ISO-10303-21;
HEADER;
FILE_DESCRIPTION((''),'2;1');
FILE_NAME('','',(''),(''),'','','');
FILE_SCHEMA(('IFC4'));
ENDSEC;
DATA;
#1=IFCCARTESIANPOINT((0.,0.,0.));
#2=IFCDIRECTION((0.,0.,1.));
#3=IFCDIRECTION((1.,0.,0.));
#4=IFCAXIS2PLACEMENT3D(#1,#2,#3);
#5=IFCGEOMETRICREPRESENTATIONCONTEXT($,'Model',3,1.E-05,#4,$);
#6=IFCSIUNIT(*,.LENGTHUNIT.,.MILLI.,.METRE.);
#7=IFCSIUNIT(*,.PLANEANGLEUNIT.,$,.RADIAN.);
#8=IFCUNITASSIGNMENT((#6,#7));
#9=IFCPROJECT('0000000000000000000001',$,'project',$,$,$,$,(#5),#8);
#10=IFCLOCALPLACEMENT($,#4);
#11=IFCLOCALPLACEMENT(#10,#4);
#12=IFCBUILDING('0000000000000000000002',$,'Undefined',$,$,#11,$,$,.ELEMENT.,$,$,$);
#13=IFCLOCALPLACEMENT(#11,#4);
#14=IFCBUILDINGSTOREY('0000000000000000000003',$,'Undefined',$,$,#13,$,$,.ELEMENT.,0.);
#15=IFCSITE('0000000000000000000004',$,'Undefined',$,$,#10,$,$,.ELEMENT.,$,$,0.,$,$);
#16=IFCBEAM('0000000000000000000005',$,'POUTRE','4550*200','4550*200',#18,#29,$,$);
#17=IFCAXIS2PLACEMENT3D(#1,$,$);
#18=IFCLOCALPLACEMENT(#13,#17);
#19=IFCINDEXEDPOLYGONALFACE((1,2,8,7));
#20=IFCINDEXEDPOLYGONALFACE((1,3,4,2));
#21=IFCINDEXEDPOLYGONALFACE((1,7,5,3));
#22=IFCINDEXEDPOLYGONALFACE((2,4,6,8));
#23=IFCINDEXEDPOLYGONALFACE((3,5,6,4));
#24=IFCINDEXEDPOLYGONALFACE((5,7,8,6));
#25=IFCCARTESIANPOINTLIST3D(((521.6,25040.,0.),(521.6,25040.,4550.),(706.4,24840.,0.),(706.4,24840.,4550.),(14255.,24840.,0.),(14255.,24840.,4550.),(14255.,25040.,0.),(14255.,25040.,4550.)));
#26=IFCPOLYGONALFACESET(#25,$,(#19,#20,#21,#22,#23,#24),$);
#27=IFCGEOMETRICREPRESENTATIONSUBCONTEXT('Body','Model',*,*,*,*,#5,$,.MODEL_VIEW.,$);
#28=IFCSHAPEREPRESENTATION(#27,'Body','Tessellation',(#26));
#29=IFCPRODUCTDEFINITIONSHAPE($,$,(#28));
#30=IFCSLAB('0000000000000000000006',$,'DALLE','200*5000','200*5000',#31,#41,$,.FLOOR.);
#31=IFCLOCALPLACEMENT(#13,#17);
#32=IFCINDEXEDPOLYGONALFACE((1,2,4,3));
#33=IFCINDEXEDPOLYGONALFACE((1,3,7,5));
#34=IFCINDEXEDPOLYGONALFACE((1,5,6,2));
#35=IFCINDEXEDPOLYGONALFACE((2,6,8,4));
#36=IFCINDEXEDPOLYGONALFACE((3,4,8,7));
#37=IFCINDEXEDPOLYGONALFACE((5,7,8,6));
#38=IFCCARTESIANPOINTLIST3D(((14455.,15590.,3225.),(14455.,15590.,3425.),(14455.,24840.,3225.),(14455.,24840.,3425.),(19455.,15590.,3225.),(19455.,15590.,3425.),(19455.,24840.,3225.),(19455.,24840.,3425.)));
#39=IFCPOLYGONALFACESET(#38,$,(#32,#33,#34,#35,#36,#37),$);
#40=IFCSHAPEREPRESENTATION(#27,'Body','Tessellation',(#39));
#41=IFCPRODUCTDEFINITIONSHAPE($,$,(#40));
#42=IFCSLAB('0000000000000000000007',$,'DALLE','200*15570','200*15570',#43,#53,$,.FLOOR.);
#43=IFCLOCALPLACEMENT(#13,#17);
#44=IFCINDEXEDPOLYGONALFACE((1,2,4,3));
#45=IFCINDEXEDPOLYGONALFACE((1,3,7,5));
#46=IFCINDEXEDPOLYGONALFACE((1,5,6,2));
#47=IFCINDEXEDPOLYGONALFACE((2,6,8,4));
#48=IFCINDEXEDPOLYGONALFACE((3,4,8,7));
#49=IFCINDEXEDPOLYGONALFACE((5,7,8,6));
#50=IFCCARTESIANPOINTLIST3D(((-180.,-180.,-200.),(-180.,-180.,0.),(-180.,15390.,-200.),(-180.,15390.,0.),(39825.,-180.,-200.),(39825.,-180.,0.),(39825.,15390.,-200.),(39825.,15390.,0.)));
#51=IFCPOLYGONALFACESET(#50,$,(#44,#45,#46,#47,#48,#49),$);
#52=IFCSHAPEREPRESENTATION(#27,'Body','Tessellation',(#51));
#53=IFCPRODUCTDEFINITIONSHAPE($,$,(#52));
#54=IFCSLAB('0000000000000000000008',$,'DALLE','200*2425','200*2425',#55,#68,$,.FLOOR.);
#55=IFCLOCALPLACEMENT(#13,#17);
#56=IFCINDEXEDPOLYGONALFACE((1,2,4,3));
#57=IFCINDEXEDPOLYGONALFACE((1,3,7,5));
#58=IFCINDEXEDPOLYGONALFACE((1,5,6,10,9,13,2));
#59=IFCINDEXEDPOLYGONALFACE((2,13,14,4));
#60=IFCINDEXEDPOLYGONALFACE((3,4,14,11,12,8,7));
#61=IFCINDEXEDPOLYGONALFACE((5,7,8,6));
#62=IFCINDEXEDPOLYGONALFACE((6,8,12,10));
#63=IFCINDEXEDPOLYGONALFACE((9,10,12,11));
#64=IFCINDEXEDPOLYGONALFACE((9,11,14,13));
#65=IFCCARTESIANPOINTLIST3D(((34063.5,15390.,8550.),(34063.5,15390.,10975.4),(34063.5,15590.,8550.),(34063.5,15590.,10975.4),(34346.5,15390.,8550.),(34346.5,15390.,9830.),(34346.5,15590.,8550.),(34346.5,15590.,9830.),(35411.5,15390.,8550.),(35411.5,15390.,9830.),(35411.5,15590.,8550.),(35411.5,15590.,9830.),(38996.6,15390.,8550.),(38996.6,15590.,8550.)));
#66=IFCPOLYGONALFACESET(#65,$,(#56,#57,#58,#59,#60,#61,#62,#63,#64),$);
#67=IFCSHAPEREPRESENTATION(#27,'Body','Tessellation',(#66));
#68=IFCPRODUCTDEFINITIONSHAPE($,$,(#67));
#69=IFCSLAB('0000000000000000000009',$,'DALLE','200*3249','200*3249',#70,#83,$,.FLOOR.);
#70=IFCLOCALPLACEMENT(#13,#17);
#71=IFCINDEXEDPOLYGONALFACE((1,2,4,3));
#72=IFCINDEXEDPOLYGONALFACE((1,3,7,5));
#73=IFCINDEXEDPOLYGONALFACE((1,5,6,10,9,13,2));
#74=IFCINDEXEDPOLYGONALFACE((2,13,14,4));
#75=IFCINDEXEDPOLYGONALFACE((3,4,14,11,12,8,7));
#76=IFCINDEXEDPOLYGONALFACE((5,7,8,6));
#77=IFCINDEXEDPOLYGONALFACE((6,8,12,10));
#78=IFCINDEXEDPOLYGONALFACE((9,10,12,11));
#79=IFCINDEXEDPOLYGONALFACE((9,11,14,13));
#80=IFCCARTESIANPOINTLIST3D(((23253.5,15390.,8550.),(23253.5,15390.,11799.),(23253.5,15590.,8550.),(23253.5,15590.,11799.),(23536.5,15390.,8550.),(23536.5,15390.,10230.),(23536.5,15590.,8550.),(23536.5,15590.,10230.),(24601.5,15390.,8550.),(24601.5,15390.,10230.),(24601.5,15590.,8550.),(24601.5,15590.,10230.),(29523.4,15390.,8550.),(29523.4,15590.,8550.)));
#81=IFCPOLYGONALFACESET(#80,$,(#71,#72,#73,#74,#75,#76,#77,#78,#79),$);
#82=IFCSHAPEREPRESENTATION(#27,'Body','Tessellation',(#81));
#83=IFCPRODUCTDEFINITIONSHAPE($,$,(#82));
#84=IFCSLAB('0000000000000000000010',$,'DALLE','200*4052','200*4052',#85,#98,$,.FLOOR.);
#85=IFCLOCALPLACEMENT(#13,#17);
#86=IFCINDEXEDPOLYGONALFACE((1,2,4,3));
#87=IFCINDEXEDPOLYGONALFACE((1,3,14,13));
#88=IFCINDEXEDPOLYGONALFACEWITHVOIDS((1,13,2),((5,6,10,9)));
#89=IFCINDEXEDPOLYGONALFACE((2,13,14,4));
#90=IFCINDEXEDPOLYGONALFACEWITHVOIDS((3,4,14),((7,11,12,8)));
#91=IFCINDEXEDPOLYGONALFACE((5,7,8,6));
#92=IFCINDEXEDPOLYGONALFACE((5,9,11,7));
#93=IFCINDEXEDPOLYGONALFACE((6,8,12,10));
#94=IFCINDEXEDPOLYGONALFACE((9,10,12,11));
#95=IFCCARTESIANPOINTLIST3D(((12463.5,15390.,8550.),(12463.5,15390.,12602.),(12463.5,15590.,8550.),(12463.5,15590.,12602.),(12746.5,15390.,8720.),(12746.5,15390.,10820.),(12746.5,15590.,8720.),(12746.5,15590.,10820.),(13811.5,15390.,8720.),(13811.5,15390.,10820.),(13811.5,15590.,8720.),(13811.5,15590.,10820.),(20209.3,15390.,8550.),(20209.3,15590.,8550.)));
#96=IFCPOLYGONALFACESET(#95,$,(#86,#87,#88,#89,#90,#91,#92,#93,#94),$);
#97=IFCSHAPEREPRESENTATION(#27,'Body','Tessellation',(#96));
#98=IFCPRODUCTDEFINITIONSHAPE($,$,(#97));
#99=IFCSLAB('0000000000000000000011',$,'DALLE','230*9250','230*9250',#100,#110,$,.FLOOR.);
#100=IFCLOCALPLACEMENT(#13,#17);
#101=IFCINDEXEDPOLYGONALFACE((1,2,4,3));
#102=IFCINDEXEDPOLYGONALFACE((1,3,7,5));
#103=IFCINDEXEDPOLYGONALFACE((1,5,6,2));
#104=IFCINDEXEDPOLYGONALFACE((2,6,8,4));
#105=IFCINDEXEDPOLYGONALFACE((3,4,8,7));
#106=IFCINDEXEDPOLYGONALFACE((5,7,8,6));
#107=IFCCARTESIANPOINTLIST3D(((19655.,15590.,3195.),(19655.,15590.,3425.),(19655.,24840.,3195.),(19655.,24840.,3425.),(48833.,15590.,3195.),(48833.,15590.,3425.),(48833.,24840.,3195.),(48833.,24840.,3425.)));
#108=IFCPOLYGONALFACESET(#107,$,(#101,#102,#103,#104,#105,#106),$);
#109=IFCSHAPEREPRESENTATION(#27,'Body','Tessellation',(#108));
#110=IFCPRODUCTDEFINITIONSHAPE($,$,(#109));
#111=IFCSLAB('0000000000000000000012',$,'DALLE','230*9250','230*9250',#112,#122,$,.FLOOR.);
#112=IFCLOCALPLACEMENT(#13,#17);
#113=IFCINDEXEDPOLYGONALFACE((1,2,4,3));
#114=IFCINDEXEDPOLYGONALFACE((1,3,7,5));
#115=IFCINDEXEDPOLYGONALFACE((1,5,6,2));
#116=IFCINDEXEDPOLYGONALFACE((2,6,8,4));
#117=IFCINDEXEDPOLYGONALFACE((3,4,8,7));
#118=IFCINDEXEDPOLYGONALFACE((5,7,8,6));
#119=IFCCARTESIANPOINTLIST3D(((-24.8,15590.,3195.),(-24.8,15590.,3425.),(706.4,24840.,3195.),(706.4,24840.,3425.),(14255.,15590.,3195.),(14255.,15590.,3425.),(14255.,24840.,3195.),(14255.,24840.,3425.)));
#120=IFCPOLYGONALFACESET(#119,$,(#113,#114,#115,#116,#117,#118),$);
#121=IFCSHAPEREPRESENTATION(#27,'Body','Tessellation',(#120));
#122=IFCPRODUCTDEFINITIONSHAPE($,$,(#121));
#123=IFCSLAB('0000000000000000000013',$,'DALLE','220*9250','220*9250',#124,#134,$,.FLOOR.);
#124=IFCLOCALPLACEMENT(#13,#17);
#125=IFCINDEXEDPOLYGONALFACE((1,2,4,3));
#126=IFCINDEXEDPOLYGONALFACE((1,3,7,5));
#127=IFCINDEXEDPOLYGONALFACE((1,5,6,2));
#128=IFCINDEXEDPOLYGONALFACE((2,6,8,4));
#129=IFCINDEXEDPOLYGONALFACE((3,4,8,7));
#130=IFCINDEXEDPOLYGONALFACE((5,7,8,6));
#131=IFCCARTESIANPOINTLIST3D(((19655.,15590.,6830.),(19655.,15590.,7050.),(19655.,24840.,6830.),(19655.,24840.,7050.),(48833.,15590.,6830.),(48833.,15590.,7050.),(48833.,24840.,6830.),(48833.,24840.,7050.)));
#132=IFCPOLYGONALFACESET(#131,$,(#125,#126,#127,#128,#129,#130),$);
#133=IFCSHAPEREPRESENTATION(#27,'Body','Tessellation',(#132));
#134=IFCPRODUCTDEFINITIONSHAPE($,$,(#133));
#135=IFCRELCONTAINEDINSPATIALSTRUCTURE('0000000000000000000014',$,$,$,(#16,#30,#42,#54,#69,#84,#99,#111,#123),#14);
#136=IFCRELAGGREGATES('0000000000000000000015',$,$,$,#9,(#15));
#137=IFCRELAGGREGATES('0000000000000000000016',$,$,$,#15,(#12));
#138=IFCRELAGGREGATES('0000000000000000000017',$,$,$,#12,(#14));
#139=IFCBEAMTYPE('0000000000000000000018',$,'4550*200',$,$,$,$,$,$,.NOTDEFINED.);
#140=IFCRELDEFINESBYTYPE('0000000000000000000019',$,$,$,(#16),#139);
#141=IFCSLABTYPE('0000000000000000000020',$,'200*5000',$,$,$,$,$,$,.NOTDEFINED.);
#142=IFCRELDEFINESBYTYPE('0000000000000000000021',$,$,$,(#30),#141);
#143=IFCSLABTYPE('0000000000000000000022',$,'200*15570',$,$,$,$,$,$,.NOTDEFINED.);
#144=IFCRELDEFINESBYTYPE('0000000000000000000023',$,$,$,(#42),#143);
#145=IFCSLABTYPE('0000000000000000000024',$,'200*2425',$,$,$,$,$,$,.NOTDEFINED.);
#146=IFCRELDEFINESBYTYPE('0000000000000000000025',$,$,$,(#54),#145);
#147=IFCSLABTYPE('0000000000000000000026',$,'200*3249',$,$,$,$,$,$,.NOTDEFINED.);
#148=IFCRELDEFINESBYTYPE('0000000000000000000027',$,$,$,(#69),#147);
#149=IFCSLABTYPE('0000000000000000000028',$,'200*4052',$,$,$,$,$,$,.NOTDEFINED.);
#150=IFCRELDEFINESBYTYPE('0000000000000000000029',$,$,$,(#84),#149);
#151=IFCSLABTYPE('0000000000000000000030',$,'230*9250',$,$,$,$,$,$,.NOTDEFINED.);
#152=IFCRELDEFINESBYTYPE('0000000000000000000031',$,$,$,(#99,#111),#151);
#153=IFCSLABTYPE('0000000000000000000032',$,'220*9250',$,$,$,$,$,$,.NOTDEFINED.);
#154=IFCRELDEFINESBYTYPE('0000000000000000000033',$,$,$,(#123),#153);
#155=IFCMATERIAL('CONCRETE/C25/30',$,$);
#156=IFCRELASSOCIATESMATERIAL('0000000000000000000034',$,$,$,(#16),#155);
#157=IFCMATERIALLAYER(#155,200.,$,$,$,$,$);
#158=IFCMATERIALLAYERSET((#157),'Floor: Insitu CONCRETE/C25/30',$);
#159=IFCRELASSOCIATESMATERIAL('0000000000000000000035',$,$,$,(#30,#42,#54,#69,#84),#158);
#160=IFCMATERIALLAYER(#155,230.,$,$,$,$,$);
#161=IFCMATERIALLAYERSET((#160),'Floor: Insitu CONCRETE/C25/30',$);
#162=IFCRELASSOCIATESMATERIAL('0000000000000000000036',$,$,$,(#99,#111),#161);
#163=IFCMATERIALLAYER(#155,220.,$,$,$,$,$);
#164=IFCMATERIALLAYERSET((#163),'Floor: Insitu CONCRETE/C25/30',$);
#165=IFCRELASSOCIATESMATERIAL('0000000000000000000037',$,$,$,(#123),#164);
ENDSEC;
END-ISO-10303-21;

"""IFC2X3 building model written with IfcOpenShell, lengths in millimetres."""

from ifc_helpers import new_model, si_unit, frame, origin_with_axes, origin_2d_with_axis, place, context, subcontext, project, spatial, polyline, rectangle, outline, extrude, boolean, clip, halfspace, material, layer, layer_set, layer_usage, type_object, element, save


model = new_model("IFC2X3")

# Units and contexts
model_context = context("Model", 3, precision=1e-05, world=origin_with_axes())
body_context = subcontext(model_context, "Body", "Model", "MODEL_VIEW")
ifc_project = project(units=[si_unit("LENGTHUNIT", "METRE", prefix="MILLI"), si_unit("PLANEANGLEUNIT", "RADIAN")], contexts=[model_context])

# Site, building, storey
site_placement = place(None, origin_with_axes())
site = spatial("IfcSite", under=ifc_project, at=site_placement, Name="Undefined", CompositionType="ELEMENT", RefElevation=0.0)
building_placement = place(site_placement, origin_with_axes())
building = spatial("IfcBuilding", under=site, at=building_placement, Name="Undefined", CompositionType="ELEMENT")
storey_placement = place(building_placement, origin_with_axes())
storey = spatial("IfcBuildingStorey", under=building, at=storey_placement, Name="Undefined", CompositionType="ELEMENT", Elevation=0.0)

# Beam
ifc_material_1 = material(Name="CONCRETE/C25/30")
beam_type_1 = type_object("IfcBeamType", Name="4550*200", PredefinedType="NOTDEFINED")
beam_1_placement = place(storey_placement, frame((14255.0, 24940.0, 2275.0), z_axis=(0.0, 0.0, 1.0), x_axis=(-1.0, 0.0, 0.0)))
element("IfcBeam", 1, at=beam_1_placement, inside=storey, type_object=beam_type_1, material=ifc_material_1, Name="POUTRE", Description="4550*200", ObjectType="4550*200", context=body_context, shape_type="Clipping", body=[
    clip(extrude(rectangle(XDim=200.0, YDim=4550.0, at=origin_2d_with_axis()), frame((13734.3, 0.0, 0.0), z_axis=(-1.0, 0.0, 0.0), x_axis=(0.0, -1.0, 0.0)), (0.0, 0.0, 1.0), 13734.3), halfspace(frame((13548.6, 100.0, -2275.0), z_axis=(-0.734439, -0.678675, 0.0), x_axis=(0.0, 0.0, 1.0)), True)),
])

# Slabs
ifc_layer_1 = layer(ifc_material_1, 200.0)
ifc_layer_set_1 = layer_set([ifc_layer_1], Name="Floor: Insitu CONCRETE/C25/30")
ifc_layer_usage_1 = layer_usage(ifc_layer_set_1, "AXIS3", "POSITIVE", -100.0)
slab_type_1 = type_object("IfcSlabType", Name="200*5000", PredefinedType="NOTDEFINED")
slab_1_placement = place(storey_placement, frame((14455.0, 24840.0, 3325.0), z_axis=(0.0, 0.0, 1.0), x_axis=(0.0, -1.0, 0.0)))
element("IfcSlab", 2, at=slab_1_placement, inside=storey, type_object=slab_type_1, material=ifc_layer_usage_1, Name="DALLE", Description="200*5000", ObjectType="200*5000", PredefinedType="FLOOR", context=body_context, shape_type="SweptSolid", body=[
    extrude(outline(polyline([(0.0, 0.0), (9250.0, 0.0), (9250.0, 5000.0), (0.0, 5000.0), (0.0, 0.0)])), frame((0.0, 0.0, -100.0), z_axis=(0.0, 0.0, 1.0), x_axis=(1.0, 0.0, 0.0)), (0.0, 0.0, 1.0), 200.0),
])
ifc_layer_usage_2 = layer_usage(ifc_layer_set_1, "AXIS3", "POSITIVE", -100.0)
slab_type_2 = type_object("IfcSlabType", Name="200*15570", PredefinedType="NOTDEFINED")
slab_2_placement = place(storey_placement, frame((39825.0, -180.0, -100.0), z_axis=(0.0, 0.0, 1.0), x_axis=(0.0, 1.0, 0.0)))
element("IfcSlab", 3, at=slab_2_placement, inside=storey, type_object=slab_type_2, material=ifc_layer_usage_2, Name="DALLE", Description="200*15570", ObjectType="200*15570", PredefinedType="FLOOR", context=body_context, shape_type="SweptSolid", body=[
    extrude(outline(polyline([(0.0, 0.0), (15570.0, 0.0), (15570.0, 40005.0), (0.0, 40005.0), (0.0, 0.0)])), frame((0.0, 0.0, -100.0), z_axis=(0.0, 0.0, 1.0), x_axis=(1.0, 0.0, 0.0)), (0.0, 0.0, 1.0), 200.0),
])
ifc_layer_usage_3 = layer_usage(ifc_layer_set_1, "AXIS3", "POSITIVE", -100.0)
slab_type_3 = type_object("IfcSlabType", Name="200*2425", PredefinedType="NOTDEFINED")
slab_3_placement = place(storey_placement, frame((34063.5, 15490.0, 10975.4), z_axis=(0.0, -1.0, 0.0), x_axis=(0.0, 0.0, -1.0)))
element("IfcSlab", 4, at=slab_3_placement, inside=storey, type_object=slab_type_3, material=ifc_layer_usage_3, Name="DALLE", Description="200*2425", ObjectType="200*2425", PredefinedType="FLOOR", context=body_context, shape_type="CSG", body=[
    boolean("DIFFERENCE", extrude(outline(polyline([(0.0, 0.0), (2425.4, 0.0), (2425.4, 4933.1), (0.0, 0.0)])), frame((0.0, 0.0, -100.0), z_axis=(0.0, 0.0, 1.0), x_axis=(1.0, 0.0, 0.0)), (0.0, 0.0, 1.0), 200.0), extrude(outline(polyline([(0.0, 0.0), (1700.0, 0.0), (1700.0, 1065.0), (0.0, 1065.0), (0.0, 0.0)])), frame((1145.4, 1348.0, 102.5), z_axis=(0.0, 0.0, -1.0), x_axis=(1.0, 0.0, 0.0)), (0.0, 0.0, 1.0), 205.0)),
])
ifc_layer_usage_4 = layer_usage(ifc_layer_set_1, "AXIS3", "POSITIVE", -100.0)
slab_type_4 = type_object("IfcSlabType", Name="200*3249", PredefinedType="NOTDEFINED")
slab_4_placement = place(storey_placement, frame((23253.5, 15490.0, 11799.0), z_axis=(0.0, -1.0, 0.0), x_axis=(0.0, 0.0, -1.0)))
element("IfcSlab", 5, at=slab_4_placement, inside=storey, type_object=slab_type_4, material=ifc_layer_usage_4, Name="DALLE", Description="200*3249", ObjectType="200*3249", PredefinedType="FLOOR", context=body_context, shape_type="CSG", body=[
    boolean("DIFFERENCE", extrude(outline(polyline([(0.0, 0.0), (3249.0, 0.0), (3249.0, 6269.9), (0.0, 0.0)])), frame((0.0, 0.0, -100.0), z_axis=(0.0, 0.0, 1.0), x_axis=(1.0, 0.0, 0.0)), (0.0, 0.0, 1.0), 200.0), extrude(outline(polyline([(0.0, 0.0), (2100.0, 0.0), (2100.0, 1065.0), (0.0, 1065.0), (0.0, 0.0)])), frame((1569.0, 283.0, -103.0), z_axis=(0.0, 0.0, 1.0), x_axis=(1.0, 0.0, 0.0)), (0.0, 0.0, 1.0), 206.0)),
])
ifc_layer_usage_5 = layer_usage(ifc_layer_set_1, "AXIS3", "POSITIVE", -100.0)
slab_type_5 = type_object("IfcSlabType", Name="200*4052", PredefinedType="NOTDEFINED")
slab_5_placement = place(storey_placement, frame((12463.5, 15490.0, 12602.0), z_axis=(0.0, -1.0, 0.0), x_axis=(0.0, 0.0, -1.0)))
element("IfcSlab", 6, at=slab_5_placement, inside=storey, type_object=slab_type_5, material=ifc_layer_usage_5, Name="DALLE", Description="200*4052", ObjectType="200*4052", PredefinedType="FLOOR", context=body_context, shape_type="CSG", body=[
    boolean("DIFFERENCE", extrude(outline(polyline([(0.0, 0.0), (4052.0, 0.0), (4052.0, 7745.8), (0.0, 0.0)])), frame((0.0, 0.0, -100.0), z_axis=(0.0, 0.0, 1.0), x_axis=(1.0, 0.0, 0.0)), (0.0, 0.0, 1.0), 200.0), extrude(outline(polyline([(0.0, 0.0), (2100.0, 0.0), (2100.0, 1065.0), (0.0, 1065.0), (0.0, 0.0)])), frame((1782.0, 283.0, -103.0), z_axis=(0.0, 0.0, 1.0), x_axis=(1.0, 0.0, 0.0)), (0.0, 0.0, 1.0), 206.0)),
])
ifc_layer_2 = layer(ifc_material_1, 230.0)
ifc_layer_set_2 = layer_set([ifc_layer_2], Name="Floor: Insitu CONCRETE/C25/30")
ifc_layer_usage_6 = layer_usage(ifc_layer_set_2, "AXIS3", "POSITIVE", -115.0)
slab_type_6 = type_object("IfcSlabType", Name="230*9250", PredefinedType="NOTDEFINED")
slab_6_placement = place(storey_placement, frame((19655.0, 24840.0, 3310.0), z_axis=(0.0, 0.0, 1.0), x_axis=(0.0, -1.0, 0.0)))
element("IfcSlab", 7, at=slab_6_placement, inside=storey, type_object=slab_type_6, material=ifc_layer_usage_6, Name="DALLE", Description="230*9250", ObjectType="230*9250", PredefinedType="FLOOR", context=body_context, shape_type="SweptSolid", body=[
    extrude(outline(polyline([(0.0, 0.0), (9250.0, 0.0), (9250.0, 29178.0), (0.0, 29178.0), (0.0, 0.0)])), frame((0.0, 0.0, -115.0), z_axis=(0.0, 0.0, 1.0), x_axis=(1.0, 0.0, 0.0)), (0.0, 0.0, 1.0), 230.0),
])
ifc_layer_usage_7 = layer_usage(ifc_layer_set_2, "AXIS3", "POSITIVE", -115.0)
slab_7_placement = place(storey_placement, frame((706.4, 24840.0, 3310.0), z_axis=(0.0, 0.0, 1.0), x_axis=(-0.078802, -0.99689, 0.0)))
element("IfcSlab", 8, at=slab_7_placement, inside=storey, type_object=slab_type_6, material=ifc_layer_usage_7, Name="DALLE", Description="230*9250", ObjectType="230*9250", PredefinedType="FLOOR", context=body_context, shape_type="SweptSolid", body=[
    extrude(outline(polyline([(0.0, 0.0), (9278.9, 0.0), (8153.6, 14235.4), (-1067.6, 13506.5), (0.0, 0.0)])), frame((0.0, 0.0, -115.0), z_axis=(0.0, 0.0, 1.0), x_axis=(1.0, 0.0, 0.0)), (0.0, 0.0, 1.0), 230.0),
])
ifc_layer_3 = layer(ifc_material_1, 220.0)
ifc_layer_set_3 = layer_set([ifc_layer_3], Name="Floor: Insitu CONCRETE/C25/30")
ifc_layer_usage_8 = layer_usage(ifc_layer_set_3, "AXIS3", "POSITIVE", -110.0)
slab_type_7 = type_object("IfcSlabType", Name="220*9250", PredefinedType="NOTDEFINED")
slab_8_placement = place(storey_placement, frame((19655.0, 24840.0, 6940.0), z_axis=(0.0, 0.0, 1.0), x_axis=(0.0, -1.0, 0.0)))
element("IfcSlab", 9, at=slab_8_placement, inside=storey, type_object=slab_type_7, material=ifc_layer_usage_8, Name="DALLE", Description="220*9250", ObjectType="220*9250", PredefinedType="FLOOR", context=body_context, shape_type="SweptSolid", body=[
    extrude(outline(polyline([(0.0, 0.0), (9250.0, 0.0), (9250.0, 29178.0), (0.0, 29178.0), (0.0, 0.0)])), frame((0.0, 0.0, -110.0), z_axis=(0.0, 0.0, 1.0), x_axis=(1.0, 0.0, 0.0)), (0.0, 0.0, 1.0), 220.0),
])

save(model, "model.ifc")
